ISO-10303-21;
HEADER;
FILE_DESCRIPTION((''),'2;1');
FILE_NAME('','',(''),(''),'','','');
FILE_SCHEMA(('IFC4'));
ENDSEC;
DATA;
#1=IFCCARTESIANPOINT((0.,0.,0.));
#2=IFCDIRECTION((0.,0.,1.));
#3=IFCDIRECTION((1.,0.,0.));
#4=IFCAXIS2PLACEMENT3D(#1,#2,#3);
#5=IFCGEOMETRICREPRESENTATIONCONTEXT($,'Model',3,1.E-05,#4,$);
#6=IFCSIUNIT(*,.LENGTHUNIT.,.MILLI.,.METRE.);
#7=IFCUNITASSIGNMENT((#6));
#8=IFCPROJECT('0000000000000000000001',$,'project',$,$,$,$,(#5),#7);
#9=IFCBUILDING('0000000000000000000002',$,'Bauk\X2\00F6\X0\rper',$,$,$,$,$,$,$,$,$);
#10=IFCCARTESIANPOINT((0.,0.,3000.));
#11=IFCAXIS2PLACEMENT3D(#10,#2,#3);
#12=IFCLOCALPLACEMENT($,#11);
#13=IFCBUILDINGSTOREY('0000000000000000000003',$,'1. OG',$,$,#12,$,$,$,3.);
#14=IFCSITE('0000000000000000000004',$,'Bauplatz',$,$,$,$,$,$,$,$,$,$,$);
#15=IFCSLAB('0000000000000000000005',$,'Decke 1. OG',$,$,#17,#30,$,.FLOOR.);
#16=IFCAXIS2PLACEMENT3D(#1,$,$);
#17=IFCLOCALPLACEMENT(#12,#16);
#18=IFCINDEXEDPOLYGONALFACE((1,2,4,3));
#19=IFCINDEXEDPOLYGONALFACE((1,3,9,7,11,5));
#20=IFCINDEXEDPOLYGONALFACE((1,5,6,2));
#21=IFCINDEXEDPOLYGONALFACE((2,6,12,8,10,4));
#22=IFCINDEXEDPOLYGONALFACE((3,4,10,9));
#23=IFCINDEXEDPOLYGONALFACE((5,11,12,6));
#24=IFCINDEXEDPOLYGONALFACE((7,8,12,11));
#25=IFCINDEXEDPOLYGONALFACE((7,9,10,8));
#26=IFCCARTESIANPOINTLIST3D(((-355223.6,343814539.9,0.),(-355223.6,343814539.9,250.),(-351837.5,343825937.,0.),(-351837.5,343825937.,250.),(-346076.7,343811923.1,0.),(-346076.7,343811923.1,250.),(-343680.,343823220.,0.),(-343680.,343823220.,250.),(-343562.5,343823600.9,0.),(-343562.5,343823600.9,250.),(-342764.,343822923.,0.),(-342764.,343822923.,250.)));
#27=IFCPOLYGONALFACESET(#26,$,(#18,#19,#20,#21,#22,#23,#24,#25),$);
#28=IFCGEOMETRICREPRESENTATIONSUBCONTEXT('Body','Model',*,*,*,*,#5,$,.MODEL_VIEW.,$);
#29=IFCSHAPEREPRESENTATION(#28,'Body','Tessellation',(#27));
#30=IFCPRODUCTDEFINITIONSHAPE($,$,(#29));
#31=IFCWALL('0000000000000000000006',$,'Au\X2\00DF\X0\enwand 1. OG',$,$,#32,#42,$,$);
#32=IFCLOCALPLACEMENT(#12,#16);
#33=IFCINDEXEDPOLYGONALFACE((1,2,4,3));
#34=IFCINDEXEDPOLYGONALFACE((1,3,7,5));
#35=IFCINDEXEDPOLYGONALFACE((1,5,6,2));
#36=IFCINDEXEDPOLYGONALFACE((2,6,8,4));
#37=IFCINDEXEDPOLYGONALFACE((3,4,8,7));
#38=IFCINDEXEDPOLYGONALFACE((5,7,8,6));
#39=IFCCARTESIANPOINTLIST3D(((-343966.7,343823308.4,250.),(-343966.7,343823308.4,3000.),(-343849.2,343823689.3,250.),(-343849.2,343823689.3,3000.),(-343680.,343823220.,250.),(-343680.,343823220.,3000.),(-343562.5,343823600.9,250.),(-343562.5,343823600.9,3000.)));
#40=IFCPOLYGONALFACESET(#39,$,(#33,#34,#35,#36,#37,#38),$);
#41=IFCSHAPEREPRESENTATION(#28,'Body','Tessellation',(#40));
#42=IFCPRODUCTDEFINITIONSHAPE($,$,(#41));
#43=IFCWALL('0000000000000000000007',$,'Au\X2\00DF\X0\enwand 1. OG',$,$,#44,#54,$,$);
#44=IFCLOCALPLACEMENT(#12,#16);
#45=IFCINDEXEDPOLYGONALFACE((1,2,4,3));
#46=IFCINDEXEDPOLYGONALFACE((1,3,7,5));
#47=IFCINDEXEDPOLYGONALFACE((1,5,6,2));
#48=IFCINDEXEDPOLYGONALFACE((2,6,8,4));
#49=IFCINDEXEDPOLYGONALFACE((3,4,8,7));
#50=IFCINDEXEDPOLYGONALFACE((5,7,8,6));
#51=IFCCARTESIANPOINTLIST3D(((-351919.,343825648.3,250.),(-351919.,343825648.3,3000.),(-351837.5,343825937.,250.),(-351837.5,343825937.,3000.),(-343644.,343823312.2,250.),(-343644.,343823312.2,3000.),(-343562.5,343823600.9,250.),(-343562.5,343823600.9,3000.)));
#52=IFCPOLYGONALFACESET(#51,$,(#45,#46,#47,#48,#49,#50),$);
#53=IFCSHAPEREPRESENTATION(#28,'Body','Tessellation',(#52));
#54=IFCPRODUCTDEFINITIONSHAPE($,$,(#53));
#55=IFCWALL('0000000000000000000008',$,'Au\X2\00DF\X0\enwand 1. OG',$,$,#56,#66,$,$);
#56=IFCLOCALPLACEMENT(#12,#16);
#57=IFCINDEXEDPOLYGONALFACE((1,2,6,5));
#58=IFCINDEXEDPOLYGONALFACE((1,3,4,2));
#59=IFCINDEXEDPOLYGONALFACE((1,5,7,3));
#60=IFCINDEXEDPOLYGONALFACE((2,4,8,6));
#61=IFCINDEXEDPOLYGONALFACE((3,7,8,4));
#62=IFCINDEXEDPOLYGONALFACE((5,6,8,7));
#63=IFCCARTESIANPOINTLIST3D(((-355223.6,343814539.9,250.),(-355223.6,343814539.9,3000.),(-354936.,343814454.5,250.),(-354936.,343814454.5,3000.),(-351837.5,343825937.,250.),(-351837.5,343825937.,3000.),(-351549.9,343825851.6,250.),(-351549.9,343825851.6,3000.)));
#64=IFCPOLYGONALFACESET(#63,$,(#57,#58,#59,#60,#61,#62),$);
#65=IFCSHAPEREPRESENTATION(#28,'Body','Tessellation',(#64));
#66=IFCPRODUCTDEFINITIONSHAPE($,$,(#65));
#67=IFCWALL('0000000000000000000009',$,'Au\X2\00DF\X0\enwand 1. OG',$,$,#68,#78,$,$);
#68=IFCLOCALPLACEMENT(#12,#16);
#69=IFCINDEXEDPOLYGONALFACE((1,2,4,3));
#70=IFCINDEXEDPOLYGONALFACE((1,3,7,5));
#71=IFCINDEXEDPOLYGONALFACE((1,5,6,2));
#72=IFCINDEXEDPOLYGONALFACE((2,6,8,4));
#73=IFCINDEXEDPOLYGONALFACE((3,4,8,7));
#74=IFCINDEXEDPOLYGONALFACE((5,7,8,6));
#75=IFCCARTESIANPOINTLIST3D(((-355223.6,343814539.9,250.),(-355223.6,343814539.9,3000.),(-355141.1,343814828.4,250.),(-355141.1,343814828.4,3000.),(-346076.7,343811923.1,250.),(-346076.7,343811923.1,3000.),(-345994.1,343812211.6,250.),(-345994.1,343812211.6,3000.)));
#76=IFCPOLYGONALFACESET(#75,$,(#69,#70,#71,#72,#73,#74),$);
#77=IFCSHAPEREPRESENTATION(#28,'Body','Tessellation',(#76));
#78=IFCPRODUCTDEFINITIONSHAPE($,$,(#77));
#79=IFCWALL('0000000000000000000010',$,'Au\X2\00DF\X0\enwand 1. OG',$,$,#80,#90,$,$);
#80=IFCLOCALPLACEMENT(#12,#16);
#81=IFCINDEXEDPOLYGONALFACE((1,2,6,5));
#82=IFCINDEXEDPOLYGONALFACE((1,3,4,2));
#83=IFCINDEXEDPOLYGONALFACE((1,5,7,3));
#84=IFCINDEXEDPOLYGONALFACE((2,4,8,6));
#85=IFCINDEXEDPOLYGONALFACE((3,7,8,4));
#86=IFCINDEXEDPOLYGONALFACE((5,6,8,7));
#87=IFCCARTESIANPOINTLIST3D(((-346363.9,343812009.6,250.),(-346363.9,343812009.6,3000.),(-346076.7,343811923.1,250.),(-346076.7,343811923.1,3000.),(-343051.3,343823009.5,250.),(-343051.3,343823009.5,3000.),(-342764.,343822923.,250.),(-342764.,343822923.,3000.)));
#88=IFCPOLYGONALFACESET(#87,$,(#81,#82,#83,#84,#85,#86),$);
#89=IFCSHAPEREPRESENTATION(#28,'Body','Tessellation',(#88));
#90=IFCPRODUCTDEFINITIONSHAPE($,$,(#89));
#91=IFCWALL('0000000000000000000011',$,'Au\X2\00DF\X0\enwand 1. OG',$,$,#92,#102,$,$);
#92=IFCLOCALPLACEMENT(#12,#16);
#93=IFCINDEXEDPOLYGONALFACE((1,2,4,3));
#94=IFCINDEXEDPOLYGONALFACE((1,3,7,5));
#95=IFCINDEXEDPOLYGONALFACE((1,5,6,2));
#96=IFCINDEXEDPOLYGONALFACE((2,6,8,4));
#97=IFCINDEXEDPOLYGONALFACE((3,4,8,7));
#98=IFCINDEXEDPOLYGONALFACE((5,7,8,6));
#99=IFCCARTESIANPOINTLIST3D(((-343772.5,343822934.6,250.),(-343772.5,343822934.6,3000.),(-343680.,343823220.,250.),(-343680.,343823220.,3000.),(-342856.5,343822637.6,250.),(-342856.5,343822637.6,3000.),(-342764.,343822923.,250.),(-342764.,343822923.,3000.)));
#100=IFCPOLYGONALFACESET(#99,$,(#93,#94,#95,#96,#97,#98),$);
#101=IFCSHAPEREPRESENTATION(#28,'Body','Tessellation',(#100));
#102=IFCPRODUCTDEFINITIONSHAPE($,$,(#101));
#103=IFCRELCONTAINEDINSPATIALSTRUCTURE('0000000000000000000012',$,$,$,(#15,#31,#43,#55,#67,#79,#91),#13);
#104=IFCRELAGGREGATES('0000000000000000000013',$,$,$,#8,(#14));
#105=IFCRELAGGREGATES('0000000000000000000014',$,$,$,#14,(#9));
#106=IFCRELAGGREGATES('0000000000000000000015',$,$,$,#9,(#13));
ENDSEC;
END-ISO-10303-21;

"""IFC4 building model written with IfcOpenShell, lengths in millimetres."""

from ifc_helpers import new_model, si_unit, frame, origin_with_axes, place, context, subcontext, project, spatial, indexed_curve, outline, extrude, element, save


model = new_model("IFC4")

# Units and contexts
model_context = context("Model", 3, precision=1e-05, world=origin_with_axes())
body_context = subcontext(model_context, "Body", "Model", "MODEL_VIEW")
ifc_project = project(units=[si_unit("LENGTHUNIT", "METRE", prefix="MILLI")], contexts=[model_context])

# Site, building, storey
site = spatial("IfcSite", under=ifc_project, Name="Bauplatz")
building = spatial("IfcBuilding", under=site, Name="Baukörper")
storey_placement = place(None, frame((0.0, 0.0, 3000.0), z_axis=(0.0, 0.0, 1.0), x_axis=(1.0, 0.0, 0.0)))
storey = spatial("IfcBuildingStorey", under=building, at=storey_placement, Name="1. OG", Elevation=3.0)

# Slab
slab_placement = place(storey_placement, origin_with_axes())
element("IfcSlab", 1, at=slab_placement, inside=storey, Name="Decke 1. OG", PredefinedType="FLOOR", context=body_context, shape_type="SweptSolid", body=[
    extrude(outline(indexed_curve([(-343680.0, 343823220.0), (-342764.0, 343822923.0), (-346076.7, 343811923.1), (-355223.6, 343814539.9), (-351837.5, 343825937.0), (-343562.5, 343823600.9)])), None, (0.0, 0.0, 1.0), 250.0),
])

# Walls
wall_1_placement = place(storey_placement, frame((-343680.0, 343823220.0, 250.0), z_axis=(0.0, 0.0, 1.0), x_axis=(0.294713, 0.955586, 0.0)))
element("IfcWall", 2, at=wall_1_placement, inside=storey, Name="Außenwand 1. OG", context=body_context, shape_type="SweptSolid", body=[
    extrude(outline(indexed_curve([(0.0, 0.0), (0.0, 300.0), (398.6, 300.0), (398.6, 0.0), (0.0, 0.0)], self_intersect=False)), origin_with_axes(), (0.0, 0.0, 1.0), 2750.0),
])
wall_2_placement = place(storey_placement, frame((-343562.5, 343823600.9, 250.0), z_axis=(0.0, 0.0, 1.0), x_axis=(-0.962385, 0.271691, 0.0)))
element("IfcWall", 3, at=wall_2_placement, inside=storey, Name="Außenwand 1. OG", context=body_context, shape_type="SweptSolid", body=[
    extrude(outline(indexed_curve([(0.0, 0.0), (0.0, 300.0), (8598.4, 300.0), (8598.4, 0.0), (0.0, 0.0)], self_intersect=False)), origin_with_axes(), (0.0, 0.0, 1.0), 2750.0),
])
wall_3_placement = place(storey_placement, frame((-351837.5, 343825937.0, 250.0), z_axis=(0.0, 0.0, 1.0), x_axis=(-0.284796, -0.958588, 0.0)))
element("IfcWall", 4, at=wall_3_placement, inside=storey, Name="Außenwand 1. OG", context=body_context, shape_type="SweptSolid", body=[
    extrude(outline(indexed_curve([(0.0, 0.0), (0.0, 300.0), (11889.4, 300.0), (11889.4, 0.0), (0.0, 0.0)], self_intersect=False)), origin_with_axes(), (0.0, 0.0, 1.0), 2750.0),
])
wall_4_placement = place(storey_placement, frame((-355223.6, 343814539.9, 250.0), z_axis=(0.0, 0.0, 1.0), x_axis=(0.96143, -0.275051, 0.0)))
element("IfcWall", 5, at=wall_4_placement, inside=storey, Name="Außenwand 1. OG", context=body_context, shape_type="SweptSolid", body=[
    extrude(outline(indexed_curve([(0.0, 0.0), (0.0, 300.0), (9513.9, 300.0), (9513.9, 0.0), (0.0, 0.0)], self_intersect=False)), origin_with_axes(), (0.0, 0.0, 1.0), 2750.0),
])
wall_5_placement = place(storey_placement, frame((-346076.7, 343811923.1, 250.0), z_axis=(0.0, 0.0, 1.0), x_axis=(0.288362, 0.957521, 0.0)))
element("IfcWall", 6, at=wall_5_placement, inside=storey, Name="Außenwand 1. OG", context=body_context, shape_type="SweptSolid", body=[
    extrude(outline(indexed_curve([(0.0, 0.0), (0.0, 300.0), (11487.9, 300.0), (11487.9, 0.0), (0.0, 0.0)], self_intersect=False)), origin_with_axes(), (0.0, 0.0, 1.0), 2750.0),
])
wall_6_placement = place(storey_placement, frame((-342764.0, 343822923.0, 250.0), z_axis=(0.0, 0.0, 1.0), x_axis=(-0.951248, 0.308429, 0.0)))
element("IfcWall", 7, at=wall_6_placement, inside=storey, Name="Außenwand 1. OG", context=body_context, shape_type="SweptSolid", body=[
    extrude(outline(indexed_curve([(0.0, 0.0), (0.0, 300.0), (962.9, 300.0), (962.9, 0.0), (0.0, 0.0)], self_intersect=False)), origin_with_axes(), (0.0, 0.0, 1.0), 2750.0),
])

save(model, "model.ifc")
